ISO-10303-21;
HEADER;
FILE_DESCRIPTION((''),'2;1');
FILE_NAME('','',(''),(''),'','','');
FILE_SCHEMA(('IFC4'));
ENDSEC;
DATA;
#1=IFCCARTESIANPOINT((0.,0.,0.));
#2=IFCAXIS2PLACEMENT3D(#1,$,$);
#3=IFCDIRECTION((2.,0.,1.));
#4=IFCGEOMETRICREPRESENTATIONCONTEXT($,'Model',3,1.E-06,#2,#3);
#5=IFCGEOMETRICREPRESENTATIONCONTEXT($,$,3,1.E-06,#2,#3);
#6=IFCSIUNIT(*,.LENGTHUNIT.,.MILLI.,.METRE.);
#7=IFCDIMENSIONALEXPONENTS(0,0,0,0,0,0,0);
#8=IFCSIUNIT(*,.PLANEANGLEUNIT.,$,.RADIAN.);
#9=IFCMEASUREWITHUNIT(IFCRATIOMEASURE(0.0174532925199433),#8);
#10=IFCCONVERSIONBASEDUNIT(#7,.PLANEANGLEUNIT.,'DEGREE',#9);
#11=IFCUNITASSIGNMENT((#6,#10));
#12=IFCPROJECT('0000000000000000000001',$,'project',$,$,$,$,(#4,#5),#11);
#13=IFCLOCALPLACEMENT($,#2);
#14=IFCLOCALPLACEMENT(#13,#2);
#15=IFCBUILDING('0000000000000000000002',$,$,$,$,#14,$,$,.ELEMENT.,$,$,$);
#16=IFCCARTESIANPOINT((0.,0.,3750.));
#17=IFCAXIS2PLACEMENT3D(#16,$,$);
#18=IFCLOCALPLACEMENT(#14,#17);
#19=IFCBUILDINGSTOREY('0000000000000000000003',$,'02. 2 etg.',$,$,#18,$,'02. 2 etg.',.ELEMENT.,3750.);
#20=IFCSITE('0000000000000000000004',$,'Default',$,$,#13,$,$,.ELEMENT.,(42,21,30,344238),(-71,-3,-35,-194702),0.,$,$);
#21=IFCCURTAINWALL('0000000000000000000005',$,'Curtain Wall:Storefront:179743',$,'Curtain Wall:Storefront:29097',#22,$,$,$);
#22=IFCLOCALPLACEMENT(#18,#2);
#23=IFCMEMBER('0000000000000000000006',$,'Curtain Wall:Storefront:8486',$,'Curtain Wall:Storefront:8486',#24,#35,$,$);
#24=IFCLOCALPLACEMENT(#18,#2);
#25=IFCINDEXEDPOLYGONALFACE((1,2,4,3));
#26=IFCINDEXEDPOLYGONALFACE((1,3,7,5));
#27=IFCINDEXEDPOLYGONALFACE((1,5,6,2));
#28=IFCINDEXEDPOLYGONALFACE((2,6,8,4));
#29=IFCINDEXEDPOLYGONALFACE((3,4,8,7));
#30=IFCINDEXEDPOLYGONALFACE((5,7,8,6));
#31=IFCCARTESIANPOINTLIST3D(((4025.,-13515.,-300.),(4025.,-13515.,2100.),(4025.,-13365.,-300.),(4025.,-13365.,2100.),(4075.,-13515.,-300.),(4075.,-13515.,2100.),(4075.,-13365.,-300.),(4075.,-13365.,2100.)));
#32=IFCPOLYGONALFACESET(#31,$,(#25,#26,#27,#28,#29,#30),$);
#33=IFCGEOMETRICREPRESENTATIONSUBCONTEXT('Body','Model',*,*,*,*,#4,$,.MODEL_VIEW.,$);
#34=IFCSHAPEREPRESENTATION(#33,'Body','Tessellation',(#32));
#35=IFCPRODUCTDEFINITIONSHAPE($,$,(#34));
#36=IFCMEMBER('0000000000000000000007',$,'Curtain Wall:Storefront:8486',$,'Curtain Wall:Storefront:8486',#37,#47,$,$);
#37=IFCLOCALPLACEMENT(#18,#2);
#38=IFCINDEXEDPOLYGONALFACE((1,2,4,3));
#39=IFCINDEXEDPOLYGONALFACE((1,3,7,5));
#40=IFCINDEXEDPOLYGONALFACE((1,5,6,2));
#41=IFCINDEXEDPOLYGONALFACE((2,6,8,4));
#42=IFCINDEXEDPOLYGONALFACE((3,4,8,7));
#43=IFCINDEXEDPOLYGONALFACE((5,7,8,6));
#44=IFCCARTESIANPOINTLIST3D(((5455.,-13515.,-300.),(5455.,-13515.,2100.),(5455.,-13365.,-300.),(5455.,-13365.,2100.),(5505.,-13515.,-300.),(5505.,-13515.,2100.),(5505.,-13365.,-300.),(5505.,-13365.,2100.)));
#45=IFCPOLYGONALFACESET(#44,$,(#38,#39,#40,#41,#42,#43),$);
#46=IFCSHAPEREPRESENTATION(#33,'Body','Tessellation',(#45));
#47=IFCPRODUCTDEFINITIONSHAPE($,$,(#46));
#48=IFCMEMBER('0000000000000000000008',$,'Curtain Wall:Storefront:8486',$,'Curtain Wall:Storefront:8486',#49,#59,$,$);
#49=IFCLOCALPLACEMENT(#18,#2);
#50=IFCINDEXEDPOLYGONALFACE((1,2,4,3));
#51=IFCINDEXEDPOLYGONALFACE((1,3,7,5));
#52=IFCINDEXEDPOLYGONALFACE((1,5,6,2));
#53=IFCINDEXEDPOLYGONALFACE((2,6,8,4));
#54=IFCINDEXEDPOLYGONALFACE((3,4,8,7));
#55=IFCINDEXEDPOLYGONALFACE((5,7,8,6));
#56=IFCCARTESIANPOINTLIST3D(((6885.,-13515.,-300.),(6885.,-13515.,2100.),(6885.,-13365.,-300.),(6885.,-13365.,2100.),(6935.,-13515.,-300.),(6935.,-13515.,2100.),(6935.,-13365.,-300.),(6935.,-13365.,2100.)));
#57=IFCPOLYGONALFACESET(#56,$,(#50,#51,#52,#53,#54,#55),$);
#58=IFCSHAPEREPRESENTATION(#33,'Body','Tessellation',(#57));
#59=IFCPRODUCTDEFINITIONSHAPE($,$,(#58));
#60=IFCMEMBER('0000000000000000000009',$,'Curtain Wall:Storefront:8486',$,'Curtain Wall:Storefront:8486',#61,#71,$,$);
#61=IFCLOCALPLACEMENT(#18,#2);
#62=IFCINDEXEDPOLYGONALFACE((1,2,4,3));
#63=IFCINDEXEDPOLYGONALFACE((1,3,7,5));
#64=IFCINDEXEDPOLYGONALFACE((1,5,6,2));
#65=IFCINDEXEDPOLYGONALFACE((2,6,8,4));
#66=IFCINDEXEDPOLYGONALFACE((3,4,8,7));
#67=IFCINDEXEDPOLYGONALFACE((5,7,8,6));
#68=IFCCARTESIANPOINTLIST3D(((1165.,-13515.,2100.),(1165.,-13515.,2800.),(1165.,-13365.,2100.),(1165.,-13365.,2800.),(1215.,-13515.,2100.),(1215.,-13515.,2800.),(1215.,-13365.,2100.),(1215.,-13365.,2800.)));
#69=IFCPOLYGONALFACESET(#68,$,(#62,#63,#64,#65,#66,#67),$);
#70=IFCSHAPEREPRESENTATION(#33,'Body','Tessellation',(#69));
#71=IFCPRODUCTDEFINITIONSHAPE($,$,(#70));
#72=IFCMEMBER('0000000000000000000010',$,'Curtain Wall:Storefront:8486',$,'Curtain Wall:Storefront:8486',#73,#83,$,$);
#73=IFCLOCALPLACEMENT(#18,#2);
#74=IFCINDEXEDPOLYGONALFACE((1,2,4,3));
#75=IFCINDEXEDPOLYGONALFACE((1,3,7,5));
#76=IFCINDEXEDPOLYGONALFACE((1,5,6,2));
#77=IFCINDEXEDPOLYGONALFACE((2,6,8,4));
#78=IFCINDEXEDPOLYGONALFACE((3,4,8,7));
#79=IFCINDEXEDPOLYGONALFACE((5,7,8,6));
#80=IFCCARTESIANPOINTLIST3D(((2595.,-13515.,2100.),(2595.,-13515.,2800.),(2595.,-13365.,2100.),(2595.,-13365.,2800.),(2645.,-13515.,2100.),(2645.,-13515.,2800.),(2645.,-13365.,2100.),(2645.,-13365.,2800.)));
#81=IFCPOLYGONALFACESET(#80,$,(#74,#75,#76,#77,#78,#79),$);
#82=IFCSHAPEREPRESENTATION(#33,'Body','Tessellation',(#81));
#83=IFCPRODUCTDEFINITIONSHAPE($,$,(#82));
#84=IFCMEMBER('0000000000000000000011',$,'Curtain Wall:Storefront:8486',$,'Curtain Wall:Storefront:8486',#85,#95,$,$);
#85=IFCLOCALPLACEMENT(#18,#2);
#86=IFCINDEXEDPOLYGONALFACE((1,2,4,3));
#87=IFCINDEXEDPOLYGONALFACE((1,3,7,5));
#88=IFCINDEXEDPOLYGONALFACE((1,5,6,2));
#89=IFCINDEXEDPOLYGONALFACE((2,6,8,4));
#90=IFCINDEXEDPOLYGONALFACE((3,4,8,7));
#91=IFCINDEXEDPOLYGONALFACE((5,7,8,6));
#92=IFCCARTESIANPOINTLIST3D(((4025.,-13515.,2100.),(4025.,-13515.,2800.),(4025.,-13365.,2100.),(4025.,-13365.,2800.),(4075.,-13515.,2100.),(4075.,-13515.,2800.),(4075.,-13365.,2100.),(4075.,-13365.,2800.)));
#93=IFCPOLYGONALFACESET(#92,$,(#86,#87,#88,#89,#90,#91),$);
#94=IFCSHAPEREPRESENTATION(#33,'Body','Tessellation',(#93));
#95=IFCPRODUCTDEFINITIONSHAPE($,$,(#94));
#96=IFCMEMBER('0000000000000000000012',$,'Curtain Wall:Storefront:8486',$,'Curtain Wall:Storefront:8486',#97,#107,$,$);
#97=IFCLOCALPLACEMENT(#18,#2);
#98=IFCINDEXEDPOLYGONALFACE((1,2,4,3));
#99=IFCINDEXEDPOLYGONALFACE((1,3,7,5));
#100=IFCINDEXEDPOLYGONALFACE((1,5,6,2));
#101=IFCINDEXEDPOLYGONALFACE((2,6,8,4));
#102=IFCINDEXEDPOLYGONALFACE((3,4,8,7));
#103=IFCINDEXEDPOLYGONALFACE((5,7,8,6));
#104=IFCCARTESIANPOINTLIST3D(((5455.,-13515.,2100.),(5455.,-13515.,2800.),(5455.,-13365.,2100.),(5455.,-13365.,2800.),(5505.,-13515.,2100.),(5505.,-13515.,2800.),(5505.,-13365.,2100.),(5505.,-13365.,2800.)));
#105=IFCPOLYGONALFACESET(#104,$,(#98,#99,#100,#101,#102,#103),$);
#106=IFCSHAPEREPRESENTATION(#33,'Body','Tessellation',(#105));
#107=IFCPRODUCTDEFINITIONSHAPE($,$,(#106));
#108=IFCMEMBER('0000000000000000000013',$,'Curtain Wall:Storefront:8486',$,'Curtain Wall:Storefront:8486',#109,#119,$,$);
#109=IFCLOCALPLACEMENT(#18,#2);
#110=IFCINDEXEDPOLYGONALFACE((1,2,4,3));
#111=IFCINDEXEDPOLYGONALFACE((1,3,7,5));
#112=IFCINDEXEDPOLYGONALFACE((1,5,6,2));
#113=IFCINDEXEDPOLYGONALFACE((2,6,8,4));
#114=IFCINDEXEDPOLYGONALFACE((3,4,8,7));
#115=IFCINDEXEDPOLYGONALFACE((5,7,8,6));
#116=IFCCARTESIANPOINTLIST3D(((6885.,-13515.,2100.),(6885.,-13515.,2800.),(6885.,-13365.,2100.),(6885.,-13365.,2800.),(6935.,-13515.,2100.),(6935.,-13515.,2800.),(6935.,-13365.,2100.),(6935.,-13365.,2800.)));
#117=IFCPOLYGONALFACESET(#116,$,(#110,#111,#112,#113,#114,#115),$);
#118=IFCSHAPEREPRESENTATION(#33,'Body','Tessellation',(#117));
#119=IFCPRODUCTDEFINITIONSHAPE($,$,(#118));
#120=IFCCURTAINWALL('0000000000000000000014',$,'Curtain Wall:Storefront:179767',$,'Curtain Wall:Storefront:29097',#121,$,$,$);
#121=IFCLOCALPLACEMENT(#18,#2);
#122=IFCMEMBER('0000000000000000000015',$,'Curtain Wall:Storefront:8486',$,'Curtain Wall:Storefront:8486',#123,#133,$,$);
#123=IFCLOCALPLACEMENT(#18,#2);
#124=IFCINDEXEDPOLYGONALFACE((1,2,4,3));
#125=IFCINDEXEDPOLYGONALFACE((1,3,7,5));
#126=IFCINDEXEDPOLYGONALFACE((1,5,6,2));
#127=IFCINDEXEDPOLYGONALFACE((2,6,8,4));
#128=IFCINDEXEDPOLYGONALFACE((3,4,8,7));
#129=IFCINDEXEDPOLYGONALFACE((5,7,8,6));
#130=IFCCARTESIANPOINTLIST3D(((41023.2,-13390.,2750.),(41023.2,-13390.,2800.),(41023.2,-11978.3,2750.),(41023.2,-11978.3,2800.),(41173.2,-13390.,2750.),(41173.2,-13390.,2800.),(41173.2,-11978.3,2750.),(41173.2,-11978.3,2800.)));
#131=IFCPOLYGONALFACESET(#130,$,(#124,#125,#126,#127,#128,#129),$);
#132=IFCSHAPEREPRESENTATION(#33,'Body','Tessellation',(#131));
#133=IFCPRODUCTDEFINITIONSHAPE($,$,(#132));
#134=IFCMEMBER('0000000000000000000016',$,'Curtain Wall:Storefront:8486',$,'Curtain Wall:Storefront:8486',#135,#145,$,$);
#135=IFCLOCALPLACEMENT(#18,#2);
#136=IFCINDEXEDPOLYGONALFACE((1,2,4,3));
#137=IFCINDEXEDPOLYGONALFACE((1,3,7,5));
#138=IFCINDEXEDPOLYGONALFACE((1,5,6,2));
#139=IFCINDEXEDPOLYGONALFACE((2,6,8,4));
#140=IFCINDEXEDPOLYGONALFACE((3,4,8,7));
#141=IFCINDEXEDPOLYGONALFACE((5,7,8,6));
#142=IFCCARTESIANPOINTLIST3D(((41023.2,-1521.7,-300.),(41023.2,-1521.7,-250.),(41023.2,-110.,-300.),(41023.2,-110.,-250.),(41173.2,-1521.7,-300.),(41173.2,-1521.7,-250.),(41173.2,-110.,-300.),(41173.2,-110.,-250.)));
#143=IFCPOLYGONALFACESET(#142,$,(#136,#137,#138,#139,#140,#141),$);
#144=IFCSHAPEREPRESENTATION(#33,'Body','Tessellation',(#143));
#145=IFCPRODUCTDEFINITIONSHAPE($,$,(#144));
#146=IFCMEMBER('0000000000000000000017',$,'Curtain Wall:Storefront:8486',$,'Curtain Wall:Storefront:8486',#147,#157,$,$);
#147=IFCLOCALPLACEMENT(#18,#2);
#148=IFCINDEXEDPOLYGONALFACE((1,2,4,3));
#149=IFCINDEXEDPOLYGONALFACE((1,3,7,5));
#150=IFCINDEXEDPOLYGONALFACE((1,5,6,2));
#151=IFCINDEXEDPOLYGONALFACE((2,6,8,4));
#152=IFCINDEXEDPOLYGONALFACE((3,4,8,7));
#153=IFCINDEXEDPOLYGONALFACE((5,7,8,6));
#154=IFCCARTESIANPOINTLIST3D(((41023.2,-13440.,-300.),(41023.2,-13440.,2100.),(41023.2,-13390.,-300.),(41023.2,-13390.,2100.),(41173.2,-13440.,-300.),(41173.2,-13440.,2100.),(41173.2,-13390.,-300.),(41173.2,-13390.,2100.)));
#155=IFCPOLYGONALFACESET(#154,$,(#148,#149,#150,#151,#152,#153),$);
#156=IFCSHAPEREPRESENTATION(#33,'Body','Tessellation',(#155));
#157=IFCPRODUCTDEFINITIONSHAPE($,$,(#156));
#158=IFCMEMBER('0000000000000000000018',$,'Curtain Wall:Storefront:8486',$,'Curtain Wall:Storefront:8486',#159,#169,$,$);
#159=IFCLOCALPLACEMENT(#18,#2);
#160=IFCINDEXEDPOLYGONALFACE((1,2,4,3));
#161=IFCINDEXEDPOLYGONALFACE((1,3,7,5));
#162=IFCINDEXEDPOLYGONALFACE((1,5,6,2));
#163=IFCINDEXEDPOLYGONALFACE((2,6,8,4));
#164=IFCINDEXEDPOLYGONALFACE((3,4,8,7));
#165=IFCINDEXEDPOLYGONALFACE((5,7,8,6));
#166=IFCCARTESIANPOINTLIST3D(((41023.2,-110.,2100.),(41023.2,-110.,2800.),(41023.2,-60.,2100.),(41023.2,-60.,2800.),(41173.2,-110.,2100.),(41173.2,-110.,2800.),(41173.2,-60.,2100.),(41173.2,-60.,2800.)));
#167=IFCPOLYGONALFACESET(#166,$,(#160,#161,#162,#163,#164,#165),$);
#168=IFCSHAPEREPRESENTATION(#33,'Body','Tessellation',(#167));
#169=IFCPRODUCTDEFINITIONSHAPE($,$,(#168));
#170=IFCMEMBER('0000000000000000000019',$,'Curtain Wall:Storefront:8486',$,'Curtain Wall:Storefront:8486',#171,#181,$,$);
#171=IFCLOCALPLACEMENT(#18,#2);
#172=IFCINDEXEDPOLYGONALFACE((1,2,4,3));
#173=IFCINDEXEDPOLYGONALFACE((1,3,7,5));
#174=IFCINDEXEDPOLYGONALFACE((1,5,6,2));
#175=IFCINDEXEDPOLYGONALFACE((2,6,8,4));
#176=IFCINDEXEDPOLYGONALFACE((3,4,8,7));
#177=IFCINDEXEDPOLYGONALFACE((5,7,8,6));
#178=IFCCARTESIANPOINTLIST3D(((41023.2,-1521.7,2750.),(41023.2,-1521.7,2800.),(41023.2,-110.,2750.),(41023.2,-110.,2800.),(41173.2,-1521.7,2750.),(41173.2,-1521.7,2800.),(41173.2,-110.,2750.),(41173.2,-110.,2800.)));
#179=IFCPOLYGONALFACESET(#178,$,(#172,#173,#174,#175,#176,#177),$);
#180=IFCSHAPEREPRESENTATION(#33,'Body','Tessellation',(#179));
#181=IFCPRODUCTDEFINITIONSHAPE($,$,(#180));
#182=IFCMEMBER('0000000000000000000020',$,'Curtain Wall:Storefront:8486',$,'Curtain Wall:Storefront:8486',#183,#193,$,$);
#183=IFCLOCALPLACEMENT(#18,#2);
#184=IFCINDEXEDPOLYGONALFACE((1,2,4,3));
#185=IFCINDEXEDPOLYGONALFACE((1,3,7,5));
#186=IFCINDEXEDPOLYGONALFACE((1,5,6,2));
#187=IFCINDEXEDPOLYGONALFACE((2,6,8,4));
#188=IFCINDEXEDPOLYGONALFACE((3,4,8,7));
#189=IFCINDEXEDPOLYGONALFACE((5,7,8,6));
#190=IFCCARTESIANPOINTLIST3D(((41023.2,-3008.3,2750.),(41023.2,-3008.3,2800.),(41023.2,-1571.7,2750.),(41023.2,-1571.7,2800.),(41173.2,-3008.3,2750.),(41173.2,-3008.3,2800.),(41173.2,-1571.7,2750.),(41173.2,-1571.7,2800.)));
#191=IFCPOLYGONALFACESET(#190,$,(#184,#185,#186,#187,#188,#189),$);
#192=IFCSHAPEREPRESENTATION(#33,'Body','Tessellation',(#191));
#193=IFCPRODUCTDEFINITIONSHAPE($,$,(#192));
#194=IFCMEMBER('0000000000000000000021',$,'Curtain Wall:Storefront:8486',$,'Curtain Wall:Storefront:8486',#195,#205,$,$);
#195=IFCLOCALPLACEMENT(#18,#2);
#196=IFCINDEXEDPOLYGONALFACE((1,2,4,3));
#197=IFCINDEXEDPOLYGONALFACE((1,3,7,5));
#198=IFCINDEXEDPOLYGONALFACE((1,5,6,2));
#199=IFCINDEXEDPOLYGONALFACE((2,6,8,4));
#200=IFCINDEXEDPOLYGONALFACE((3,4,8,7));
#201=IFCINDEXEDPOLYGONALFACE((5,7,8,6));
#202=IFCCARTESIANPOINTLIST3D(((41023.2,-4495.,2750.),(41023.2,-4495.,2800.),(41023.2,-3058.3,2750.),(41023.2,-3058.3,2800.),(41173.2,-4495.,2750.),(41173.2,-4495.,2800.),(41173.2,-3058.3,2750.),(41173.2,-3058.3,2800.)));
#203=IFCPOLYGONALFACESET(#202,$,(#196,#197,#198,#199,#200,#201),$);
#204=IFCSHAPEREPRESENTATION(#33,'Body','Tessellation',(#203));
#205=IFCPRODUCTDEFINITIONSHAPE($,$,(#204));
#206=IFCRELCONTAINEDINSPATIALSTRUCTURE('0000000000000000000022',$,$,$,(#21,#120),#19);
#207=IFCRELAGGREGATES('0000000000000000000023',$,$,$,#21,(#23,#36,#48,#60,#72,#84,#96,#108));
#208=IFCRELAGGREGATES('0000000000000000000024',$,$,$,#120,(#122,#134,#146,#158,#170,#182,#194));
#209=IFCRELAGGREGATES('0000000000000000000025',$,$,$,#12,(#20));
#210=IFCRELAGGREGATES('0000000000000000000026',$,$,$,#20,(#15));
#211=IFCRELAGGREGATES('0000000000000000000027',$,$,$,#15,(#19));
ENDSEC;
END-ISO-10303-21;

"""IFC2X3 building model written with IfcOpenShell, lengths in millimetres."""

from ifc_helpers import new_model, entity, si_unit, converted_unit, direction, frame, frame_2d, origin, origin_2d_with_axis, place, context, subcontext, project, spatial, rectangle, extrude, element, aggregate, save


model = new_model("IFC2X3")

# Units and contexts
model_context = context("Model", 3, precision=1e-06, world=origin(), true_north=direction((2.0, 0.0, 1.0)))
context_of_model = context(None, 3, precision=1e-06, world=origin(), true_north=direction((2.0, 0.0, 1.0)))
body_context = subcontext(model_context, "Body", "Model", "MODEL_VIEW")
ifc_project = project(units=[si_unit("LENGTHUNIT", "METRE", prefix="MILLI"), converted_unit("PLANEANGLEUNIT", "DEGREE", entity("IfcRatioMeasure", 0.0174532925199433), si_unit("PLANEANGLEUNIT", "RADIAN"), dimensions=[0, 0, 0, 0, 0, 0, 0])], contexts=[model_context, context_of_model])

# Site, building, storey
site_placement = place(None, origin())
site = spatial("IfcSite", under=ifc_project, at=site_placement, Name="Default", CompositionType="ELEMENT", RefLatitude=(42, 21, 30, 344238), RefLongitude=(-71, -3, -35, -194702), RefElevation=0.0)
building_placement = place(site_placement, origin())
building = spatial("IfcBuilding", under=site, at=building_placement, CompositionType="ELEMENT")
storey_placement = place(building_placement, frame((0.0, 0.0, 3750.0)))
storey = spatial("IfcBuildingStorey", under=building, at=storey_placement, Name="02. 2 etg.", LongName="02. 2 etg.", CompositionType="ELEMENT", Elevation=3750.0)

# Curtain walls, members
curtain_wall_1_placement = place(storey_placement, origin())
curtain_wall_1 = element("IfcCurtainWall", 1, at=curtain_wall_1_placement, inside=storey, Name="Curtain Wall:Storefront:179743", ObjectType="Curtain Wall:Storefront:29097")
member_1_placement = place(storey_placement, origin())
member_1 = element("IfcMember", 2, at=member_1_placement, Name="Curtain Wall:Storefront:8486", ObjectType="Curtain Wall:Storefront:8486", context=body_context, shape_type="SweptSolid", body=[
    extrude(rectangle(XDim=150.0, YDim=50.0, at=frame_2d((0.0, 0.0), x_axis=(1.0, 0.0))), frame((4050.0, -13440.0, -300.0), z_axis=(0.0, 0.0, 1.0), x_axis=(0.0, 1.0, 0.0)), (0.0, 0.0, 1.0), 2400.0),
])
member_2_placement = place(storey_placement, origin())
member_2 = element("IfcMember", 3, at=member_2_placement, Name="Curtain Wall:Storefront:8486", ObjectType="Curtain Wall:Storefront:8486", context=body_context, shape_type="SweptSolid", body=[
    extrude(rectangle(XDim=150.0, YDim=50.0, at=frame_2d((0.0, 0.0), x_axis=(1.0, 0.0))), frame((5480.0, -13440.0, -300.0), z_axis=(0.0, 0.0, 1.0), x_axis=(0.0, 1.0, 0.0)), (0.0, 0.0, 1.0), 2400.0),
])
member_3_placement = place(storey_placement, origin())
member_3 = element("IfcMember", 4, at=member_3_placement, Name="Curtain Wall:Storefront:8486", ObjectType="Curtain Wall:Storefront:8486", context=body_context, shape_type="SweptSolid", body=[
    extrude(rectangle(XDim=150.0, YDim=50.0, at=origin_2d_with_axis()), frame((6910.0, -13440.0, -300.0), z_axis=(0.0, 0.0, 1.0), x_axis=(0.0, 1.0, 0.0)), (0.0, 0.0, 1.0), 2400.0),
])
member_4_placement = place(storey_placement, origin())
member_4 = element("IfcMember", 5, at=member_4_placement, Name="Curtain Wall:Storefront:8486", ObjectType="Curtain Wall:Storefront:8486", context=body_context, shape_type="SweptSolid", body=[
    extrude(rectangle(XDim=150.0, YDim=50.0, at=origin_2d_with_axis()), frame((1190.0, -13440.0, 2100.0), z_axis=(0.0, 0.0, 1.0), x_axis=(0.0, 1.0, 0.0)), (0.0, 0.0, 1.0), 700.0),
])
member_5_placement = place(storey_placement, origin())
member_5 = element("IfcMember", 6, at=member_5_placement, Name="Curtain Wall:Storefront:8486", ObjectType="Curtain Wall:Storefront:8486", context=body_context, shape_type="SweptSolid", body=[
    extrude(rectangle(XDim=150.0, YDim=50.0, at=frame_2d((0.0, 0.0), x_axis=(1.0, 0.0))), frame((2620.0, -13440.0, 2100.0), z_axis=(0.0, 0.0, 1.0), x_axis=(0.0, 1.0, 0.0)), (0.0, 0.0, 1.0), 700.0),
])
member_6_placement = place(storey_placement, origin())
member_6 = element("IfcMember", 7, at=member_6_placement, Name="Curtain Wall:Storefront:8486", ObjectType="Curtain Wall:Storefront:8486", context=body_context, shape_type="SweptSolid", body=[
    extrude(rectangle(XDim=150.0, YDim=50.0, at=frame_2d((0.0, 0.0), x_axis=(1.0, 0.0))), frame((4050.0, -13440.0, 2100.0), z_axis=(0.0, 0.0, 1.0), x_axis=(0.0, 1.0, 0.0)), (0.0, 0.0, 1.0), 700.0),
])
member_7_placement = place(storey_placement, origin())
member_7 = element("IfcMember", 8, at=member_7_placement, Name="Curtain Wall:Storefront:8486", ObjectType="Curtain Wall:Storefront:8486", context=body_context, shape_type="SweptSolid", body=[
    extrude(rectangle(XDim=150.0, YDim=50.0, at=frame_2d((0.0, 0.0), x_axis=(1.0, 0.0))), frame((5480.0, -13440.0, 2100.0), z_axis=(0.0, 0.0, 1.0), x_axis=(0.0, 1.0, 0.0)), (0.0, 0.0, 1.0), 700.0),
])
member_8_placement = place(storey_placement, origin())
member_8 = element("IfcMember", 9, at=member_8_placement, Name="Curtain Wall:Storefront:8486", ObjectType="Curtain Wall:Storefront:8486", context=body_context, shape_type="SweptSolid", body=[
    extrude(rectangle(XDim=150.0, YDim=50.0, at=origin_2d_with_axis()), frame((6910.0, -13440.0, 2100.0), z_axis=(0.0, 0.0, 1.0), x_axis=(0.0, 1.0, 0.0)), (0.0, 0.0, 1.0), 700.0),
])
aggregate(curtain_wall_1, [member_1, member_2, member_3, member_4, member_5, member_6, member_7, member_8])
curtain_wall_2_placement = place(storey_placement, origin())
curtain_wall_2 = element("IfcCurtainWall", 10, at=curtain_wall_2_placement, inside=storey, Name="Curtain Wall:Storefront:179767", ObjectType="Curtain Wall:Storefront:29097")
member_9_placement = place(storey_placement, origin())
member_9 = element("IfcMember", 11, at=member_9_placement, Name="Curtain Wall:Storefront:8486", ObjectType="Curtain Wall:Storefront:8486", context=body_context, shape_type="SweptSolid", body=[
    extrude(rectangle(XDim=1411.7, YDim=150.0, at=frame_2d((0.0, 0.0), x_axis=(1.0, 0.0))), frame((41098.2, -12684.2, 2750.0), z_axis=(0.0, 0.0, 1.0), x_axis=(0.0, 1.0, 0.0)), (0.0, 0.0, 1.0), 50.0),
])
member_10_placement = place(storey_placement, origin())
member_10 = element("IfcMember", 12, at=member_10_placement, Name="Curtain Wall:Storefront:8486", ObjectType="Curtain Wall:Storefront:8486", context=body_context, shape_type="SweptSolid", body=[
    extrude(rectangle(XDim=1411.7, YDim=150.0, at=origin_2d_with_axis()), frame((41098.2, -815.8, -300.0), z_axis=(0.0, 0.0, 1.0), x_axis=(0.0, -1.0, 0.0)), (0.0, 0.0, 1.0), 50.0),
])
member_11_placement = place(storey_placement, origin())
member_11 = element("IfcMember", 13, at=member_11_placement, Name="Curtain Wall:Storefront:8486", ObjectType="Curtain Wall:Storefront:8486", context=body_context, shape_type="SweptSolid", body=[
    extrude(rectangle(XDim=150.0, YDim=50.0, at=origin_2d_with_axis()), frame((41098.2, -13415.0, -300.0)), (0.0, 0.0, 1.0), 2400.0),
])
member_12_placement = place(storey_placement, origin())
member_12 = element("IfcMember", 14, at=member_12_placement, Name="Curtain Wall:Storefront:8486", ObjectType="Curtain Wall:Storefront:8486", context=body_context, shape_type="SweptSolid", body=[
    extrude(rectangle(XDim=50.0, YDim=150.0, at=origin_2d_with_axis()), frame((41098.2, -85.0, 2100.0), z_axis=(0.0, 0.0, 1.0), x_axis=(0.0, -1.0, 0.0)), (0.0, 0.0, 1.0), 700.0),
])
member_13_placement = place(storey_placement, origin())
member_13 = element("IfcMember", 15, at=member_13_placement, Name="Curtain Wall:Storefront:8486", ObjectType="Curtain Wall:Storefront:8486", context=body_context, shape_type="SweptSolid", body=[
    extrude(rectangle(XDim=1411.7, YDim=150.0, at=origin_2d_with_axis()), frame((41098.2, -815.8, 2750.0), z_axis=(0.0, 0.0, 1.0), x_axis=(0.0, 1.0, 0.0)), (0.0, 0.0, 1.0), 50.0),
])
member_14_placement = place(storey_placement, origin())
member_14 = element("IfcMember", 16, at=member_14_placement, Name="Curtain Wall:Storefront:8486", ObjectType="Curtain Wall:Storefront:8486", context=body_context, shape_type="SweptSolid", body=[
    extrude(rectangle(XDim=1436.7, YDim=150.0, at=frame_2d((0.0, 0.0), x_axis=(1.0, 0.0))), frame((41098.2, -2290.0, 2750.0), z_axis=(0.0, 0.0, 1.0), x_axis=(0.0, 1.0, 0.0)), (0.0, 0.0, 1.0), 50.0),
])
member_15_placement = place(storey_placement, origin())
member_15 = element("IfcMember", 17, at=member_15_placement, Name="Curtain Wall:Storefront:8486", ObjectType="Curtain Wall:Storefront:8486", context=body_context, shape_type="SweptSolid", body=[
    extrude(rectangle(XDim=1436.7, YDim=150.0, at=origin_2d_with_axis()), frame((41098.2, -3776.7, 2750.0), z_axis=(0.0, 0.0, 1.0), x_axis=(0.0, 1.0, 0.0)), (0.0, 0.0, 1.0), 50.0),
])
aggregate(curtain_wall_2, [member_9, member_10, member_11, member_12, member_13, member_14, member_15])

save(model, "model.ifc")
